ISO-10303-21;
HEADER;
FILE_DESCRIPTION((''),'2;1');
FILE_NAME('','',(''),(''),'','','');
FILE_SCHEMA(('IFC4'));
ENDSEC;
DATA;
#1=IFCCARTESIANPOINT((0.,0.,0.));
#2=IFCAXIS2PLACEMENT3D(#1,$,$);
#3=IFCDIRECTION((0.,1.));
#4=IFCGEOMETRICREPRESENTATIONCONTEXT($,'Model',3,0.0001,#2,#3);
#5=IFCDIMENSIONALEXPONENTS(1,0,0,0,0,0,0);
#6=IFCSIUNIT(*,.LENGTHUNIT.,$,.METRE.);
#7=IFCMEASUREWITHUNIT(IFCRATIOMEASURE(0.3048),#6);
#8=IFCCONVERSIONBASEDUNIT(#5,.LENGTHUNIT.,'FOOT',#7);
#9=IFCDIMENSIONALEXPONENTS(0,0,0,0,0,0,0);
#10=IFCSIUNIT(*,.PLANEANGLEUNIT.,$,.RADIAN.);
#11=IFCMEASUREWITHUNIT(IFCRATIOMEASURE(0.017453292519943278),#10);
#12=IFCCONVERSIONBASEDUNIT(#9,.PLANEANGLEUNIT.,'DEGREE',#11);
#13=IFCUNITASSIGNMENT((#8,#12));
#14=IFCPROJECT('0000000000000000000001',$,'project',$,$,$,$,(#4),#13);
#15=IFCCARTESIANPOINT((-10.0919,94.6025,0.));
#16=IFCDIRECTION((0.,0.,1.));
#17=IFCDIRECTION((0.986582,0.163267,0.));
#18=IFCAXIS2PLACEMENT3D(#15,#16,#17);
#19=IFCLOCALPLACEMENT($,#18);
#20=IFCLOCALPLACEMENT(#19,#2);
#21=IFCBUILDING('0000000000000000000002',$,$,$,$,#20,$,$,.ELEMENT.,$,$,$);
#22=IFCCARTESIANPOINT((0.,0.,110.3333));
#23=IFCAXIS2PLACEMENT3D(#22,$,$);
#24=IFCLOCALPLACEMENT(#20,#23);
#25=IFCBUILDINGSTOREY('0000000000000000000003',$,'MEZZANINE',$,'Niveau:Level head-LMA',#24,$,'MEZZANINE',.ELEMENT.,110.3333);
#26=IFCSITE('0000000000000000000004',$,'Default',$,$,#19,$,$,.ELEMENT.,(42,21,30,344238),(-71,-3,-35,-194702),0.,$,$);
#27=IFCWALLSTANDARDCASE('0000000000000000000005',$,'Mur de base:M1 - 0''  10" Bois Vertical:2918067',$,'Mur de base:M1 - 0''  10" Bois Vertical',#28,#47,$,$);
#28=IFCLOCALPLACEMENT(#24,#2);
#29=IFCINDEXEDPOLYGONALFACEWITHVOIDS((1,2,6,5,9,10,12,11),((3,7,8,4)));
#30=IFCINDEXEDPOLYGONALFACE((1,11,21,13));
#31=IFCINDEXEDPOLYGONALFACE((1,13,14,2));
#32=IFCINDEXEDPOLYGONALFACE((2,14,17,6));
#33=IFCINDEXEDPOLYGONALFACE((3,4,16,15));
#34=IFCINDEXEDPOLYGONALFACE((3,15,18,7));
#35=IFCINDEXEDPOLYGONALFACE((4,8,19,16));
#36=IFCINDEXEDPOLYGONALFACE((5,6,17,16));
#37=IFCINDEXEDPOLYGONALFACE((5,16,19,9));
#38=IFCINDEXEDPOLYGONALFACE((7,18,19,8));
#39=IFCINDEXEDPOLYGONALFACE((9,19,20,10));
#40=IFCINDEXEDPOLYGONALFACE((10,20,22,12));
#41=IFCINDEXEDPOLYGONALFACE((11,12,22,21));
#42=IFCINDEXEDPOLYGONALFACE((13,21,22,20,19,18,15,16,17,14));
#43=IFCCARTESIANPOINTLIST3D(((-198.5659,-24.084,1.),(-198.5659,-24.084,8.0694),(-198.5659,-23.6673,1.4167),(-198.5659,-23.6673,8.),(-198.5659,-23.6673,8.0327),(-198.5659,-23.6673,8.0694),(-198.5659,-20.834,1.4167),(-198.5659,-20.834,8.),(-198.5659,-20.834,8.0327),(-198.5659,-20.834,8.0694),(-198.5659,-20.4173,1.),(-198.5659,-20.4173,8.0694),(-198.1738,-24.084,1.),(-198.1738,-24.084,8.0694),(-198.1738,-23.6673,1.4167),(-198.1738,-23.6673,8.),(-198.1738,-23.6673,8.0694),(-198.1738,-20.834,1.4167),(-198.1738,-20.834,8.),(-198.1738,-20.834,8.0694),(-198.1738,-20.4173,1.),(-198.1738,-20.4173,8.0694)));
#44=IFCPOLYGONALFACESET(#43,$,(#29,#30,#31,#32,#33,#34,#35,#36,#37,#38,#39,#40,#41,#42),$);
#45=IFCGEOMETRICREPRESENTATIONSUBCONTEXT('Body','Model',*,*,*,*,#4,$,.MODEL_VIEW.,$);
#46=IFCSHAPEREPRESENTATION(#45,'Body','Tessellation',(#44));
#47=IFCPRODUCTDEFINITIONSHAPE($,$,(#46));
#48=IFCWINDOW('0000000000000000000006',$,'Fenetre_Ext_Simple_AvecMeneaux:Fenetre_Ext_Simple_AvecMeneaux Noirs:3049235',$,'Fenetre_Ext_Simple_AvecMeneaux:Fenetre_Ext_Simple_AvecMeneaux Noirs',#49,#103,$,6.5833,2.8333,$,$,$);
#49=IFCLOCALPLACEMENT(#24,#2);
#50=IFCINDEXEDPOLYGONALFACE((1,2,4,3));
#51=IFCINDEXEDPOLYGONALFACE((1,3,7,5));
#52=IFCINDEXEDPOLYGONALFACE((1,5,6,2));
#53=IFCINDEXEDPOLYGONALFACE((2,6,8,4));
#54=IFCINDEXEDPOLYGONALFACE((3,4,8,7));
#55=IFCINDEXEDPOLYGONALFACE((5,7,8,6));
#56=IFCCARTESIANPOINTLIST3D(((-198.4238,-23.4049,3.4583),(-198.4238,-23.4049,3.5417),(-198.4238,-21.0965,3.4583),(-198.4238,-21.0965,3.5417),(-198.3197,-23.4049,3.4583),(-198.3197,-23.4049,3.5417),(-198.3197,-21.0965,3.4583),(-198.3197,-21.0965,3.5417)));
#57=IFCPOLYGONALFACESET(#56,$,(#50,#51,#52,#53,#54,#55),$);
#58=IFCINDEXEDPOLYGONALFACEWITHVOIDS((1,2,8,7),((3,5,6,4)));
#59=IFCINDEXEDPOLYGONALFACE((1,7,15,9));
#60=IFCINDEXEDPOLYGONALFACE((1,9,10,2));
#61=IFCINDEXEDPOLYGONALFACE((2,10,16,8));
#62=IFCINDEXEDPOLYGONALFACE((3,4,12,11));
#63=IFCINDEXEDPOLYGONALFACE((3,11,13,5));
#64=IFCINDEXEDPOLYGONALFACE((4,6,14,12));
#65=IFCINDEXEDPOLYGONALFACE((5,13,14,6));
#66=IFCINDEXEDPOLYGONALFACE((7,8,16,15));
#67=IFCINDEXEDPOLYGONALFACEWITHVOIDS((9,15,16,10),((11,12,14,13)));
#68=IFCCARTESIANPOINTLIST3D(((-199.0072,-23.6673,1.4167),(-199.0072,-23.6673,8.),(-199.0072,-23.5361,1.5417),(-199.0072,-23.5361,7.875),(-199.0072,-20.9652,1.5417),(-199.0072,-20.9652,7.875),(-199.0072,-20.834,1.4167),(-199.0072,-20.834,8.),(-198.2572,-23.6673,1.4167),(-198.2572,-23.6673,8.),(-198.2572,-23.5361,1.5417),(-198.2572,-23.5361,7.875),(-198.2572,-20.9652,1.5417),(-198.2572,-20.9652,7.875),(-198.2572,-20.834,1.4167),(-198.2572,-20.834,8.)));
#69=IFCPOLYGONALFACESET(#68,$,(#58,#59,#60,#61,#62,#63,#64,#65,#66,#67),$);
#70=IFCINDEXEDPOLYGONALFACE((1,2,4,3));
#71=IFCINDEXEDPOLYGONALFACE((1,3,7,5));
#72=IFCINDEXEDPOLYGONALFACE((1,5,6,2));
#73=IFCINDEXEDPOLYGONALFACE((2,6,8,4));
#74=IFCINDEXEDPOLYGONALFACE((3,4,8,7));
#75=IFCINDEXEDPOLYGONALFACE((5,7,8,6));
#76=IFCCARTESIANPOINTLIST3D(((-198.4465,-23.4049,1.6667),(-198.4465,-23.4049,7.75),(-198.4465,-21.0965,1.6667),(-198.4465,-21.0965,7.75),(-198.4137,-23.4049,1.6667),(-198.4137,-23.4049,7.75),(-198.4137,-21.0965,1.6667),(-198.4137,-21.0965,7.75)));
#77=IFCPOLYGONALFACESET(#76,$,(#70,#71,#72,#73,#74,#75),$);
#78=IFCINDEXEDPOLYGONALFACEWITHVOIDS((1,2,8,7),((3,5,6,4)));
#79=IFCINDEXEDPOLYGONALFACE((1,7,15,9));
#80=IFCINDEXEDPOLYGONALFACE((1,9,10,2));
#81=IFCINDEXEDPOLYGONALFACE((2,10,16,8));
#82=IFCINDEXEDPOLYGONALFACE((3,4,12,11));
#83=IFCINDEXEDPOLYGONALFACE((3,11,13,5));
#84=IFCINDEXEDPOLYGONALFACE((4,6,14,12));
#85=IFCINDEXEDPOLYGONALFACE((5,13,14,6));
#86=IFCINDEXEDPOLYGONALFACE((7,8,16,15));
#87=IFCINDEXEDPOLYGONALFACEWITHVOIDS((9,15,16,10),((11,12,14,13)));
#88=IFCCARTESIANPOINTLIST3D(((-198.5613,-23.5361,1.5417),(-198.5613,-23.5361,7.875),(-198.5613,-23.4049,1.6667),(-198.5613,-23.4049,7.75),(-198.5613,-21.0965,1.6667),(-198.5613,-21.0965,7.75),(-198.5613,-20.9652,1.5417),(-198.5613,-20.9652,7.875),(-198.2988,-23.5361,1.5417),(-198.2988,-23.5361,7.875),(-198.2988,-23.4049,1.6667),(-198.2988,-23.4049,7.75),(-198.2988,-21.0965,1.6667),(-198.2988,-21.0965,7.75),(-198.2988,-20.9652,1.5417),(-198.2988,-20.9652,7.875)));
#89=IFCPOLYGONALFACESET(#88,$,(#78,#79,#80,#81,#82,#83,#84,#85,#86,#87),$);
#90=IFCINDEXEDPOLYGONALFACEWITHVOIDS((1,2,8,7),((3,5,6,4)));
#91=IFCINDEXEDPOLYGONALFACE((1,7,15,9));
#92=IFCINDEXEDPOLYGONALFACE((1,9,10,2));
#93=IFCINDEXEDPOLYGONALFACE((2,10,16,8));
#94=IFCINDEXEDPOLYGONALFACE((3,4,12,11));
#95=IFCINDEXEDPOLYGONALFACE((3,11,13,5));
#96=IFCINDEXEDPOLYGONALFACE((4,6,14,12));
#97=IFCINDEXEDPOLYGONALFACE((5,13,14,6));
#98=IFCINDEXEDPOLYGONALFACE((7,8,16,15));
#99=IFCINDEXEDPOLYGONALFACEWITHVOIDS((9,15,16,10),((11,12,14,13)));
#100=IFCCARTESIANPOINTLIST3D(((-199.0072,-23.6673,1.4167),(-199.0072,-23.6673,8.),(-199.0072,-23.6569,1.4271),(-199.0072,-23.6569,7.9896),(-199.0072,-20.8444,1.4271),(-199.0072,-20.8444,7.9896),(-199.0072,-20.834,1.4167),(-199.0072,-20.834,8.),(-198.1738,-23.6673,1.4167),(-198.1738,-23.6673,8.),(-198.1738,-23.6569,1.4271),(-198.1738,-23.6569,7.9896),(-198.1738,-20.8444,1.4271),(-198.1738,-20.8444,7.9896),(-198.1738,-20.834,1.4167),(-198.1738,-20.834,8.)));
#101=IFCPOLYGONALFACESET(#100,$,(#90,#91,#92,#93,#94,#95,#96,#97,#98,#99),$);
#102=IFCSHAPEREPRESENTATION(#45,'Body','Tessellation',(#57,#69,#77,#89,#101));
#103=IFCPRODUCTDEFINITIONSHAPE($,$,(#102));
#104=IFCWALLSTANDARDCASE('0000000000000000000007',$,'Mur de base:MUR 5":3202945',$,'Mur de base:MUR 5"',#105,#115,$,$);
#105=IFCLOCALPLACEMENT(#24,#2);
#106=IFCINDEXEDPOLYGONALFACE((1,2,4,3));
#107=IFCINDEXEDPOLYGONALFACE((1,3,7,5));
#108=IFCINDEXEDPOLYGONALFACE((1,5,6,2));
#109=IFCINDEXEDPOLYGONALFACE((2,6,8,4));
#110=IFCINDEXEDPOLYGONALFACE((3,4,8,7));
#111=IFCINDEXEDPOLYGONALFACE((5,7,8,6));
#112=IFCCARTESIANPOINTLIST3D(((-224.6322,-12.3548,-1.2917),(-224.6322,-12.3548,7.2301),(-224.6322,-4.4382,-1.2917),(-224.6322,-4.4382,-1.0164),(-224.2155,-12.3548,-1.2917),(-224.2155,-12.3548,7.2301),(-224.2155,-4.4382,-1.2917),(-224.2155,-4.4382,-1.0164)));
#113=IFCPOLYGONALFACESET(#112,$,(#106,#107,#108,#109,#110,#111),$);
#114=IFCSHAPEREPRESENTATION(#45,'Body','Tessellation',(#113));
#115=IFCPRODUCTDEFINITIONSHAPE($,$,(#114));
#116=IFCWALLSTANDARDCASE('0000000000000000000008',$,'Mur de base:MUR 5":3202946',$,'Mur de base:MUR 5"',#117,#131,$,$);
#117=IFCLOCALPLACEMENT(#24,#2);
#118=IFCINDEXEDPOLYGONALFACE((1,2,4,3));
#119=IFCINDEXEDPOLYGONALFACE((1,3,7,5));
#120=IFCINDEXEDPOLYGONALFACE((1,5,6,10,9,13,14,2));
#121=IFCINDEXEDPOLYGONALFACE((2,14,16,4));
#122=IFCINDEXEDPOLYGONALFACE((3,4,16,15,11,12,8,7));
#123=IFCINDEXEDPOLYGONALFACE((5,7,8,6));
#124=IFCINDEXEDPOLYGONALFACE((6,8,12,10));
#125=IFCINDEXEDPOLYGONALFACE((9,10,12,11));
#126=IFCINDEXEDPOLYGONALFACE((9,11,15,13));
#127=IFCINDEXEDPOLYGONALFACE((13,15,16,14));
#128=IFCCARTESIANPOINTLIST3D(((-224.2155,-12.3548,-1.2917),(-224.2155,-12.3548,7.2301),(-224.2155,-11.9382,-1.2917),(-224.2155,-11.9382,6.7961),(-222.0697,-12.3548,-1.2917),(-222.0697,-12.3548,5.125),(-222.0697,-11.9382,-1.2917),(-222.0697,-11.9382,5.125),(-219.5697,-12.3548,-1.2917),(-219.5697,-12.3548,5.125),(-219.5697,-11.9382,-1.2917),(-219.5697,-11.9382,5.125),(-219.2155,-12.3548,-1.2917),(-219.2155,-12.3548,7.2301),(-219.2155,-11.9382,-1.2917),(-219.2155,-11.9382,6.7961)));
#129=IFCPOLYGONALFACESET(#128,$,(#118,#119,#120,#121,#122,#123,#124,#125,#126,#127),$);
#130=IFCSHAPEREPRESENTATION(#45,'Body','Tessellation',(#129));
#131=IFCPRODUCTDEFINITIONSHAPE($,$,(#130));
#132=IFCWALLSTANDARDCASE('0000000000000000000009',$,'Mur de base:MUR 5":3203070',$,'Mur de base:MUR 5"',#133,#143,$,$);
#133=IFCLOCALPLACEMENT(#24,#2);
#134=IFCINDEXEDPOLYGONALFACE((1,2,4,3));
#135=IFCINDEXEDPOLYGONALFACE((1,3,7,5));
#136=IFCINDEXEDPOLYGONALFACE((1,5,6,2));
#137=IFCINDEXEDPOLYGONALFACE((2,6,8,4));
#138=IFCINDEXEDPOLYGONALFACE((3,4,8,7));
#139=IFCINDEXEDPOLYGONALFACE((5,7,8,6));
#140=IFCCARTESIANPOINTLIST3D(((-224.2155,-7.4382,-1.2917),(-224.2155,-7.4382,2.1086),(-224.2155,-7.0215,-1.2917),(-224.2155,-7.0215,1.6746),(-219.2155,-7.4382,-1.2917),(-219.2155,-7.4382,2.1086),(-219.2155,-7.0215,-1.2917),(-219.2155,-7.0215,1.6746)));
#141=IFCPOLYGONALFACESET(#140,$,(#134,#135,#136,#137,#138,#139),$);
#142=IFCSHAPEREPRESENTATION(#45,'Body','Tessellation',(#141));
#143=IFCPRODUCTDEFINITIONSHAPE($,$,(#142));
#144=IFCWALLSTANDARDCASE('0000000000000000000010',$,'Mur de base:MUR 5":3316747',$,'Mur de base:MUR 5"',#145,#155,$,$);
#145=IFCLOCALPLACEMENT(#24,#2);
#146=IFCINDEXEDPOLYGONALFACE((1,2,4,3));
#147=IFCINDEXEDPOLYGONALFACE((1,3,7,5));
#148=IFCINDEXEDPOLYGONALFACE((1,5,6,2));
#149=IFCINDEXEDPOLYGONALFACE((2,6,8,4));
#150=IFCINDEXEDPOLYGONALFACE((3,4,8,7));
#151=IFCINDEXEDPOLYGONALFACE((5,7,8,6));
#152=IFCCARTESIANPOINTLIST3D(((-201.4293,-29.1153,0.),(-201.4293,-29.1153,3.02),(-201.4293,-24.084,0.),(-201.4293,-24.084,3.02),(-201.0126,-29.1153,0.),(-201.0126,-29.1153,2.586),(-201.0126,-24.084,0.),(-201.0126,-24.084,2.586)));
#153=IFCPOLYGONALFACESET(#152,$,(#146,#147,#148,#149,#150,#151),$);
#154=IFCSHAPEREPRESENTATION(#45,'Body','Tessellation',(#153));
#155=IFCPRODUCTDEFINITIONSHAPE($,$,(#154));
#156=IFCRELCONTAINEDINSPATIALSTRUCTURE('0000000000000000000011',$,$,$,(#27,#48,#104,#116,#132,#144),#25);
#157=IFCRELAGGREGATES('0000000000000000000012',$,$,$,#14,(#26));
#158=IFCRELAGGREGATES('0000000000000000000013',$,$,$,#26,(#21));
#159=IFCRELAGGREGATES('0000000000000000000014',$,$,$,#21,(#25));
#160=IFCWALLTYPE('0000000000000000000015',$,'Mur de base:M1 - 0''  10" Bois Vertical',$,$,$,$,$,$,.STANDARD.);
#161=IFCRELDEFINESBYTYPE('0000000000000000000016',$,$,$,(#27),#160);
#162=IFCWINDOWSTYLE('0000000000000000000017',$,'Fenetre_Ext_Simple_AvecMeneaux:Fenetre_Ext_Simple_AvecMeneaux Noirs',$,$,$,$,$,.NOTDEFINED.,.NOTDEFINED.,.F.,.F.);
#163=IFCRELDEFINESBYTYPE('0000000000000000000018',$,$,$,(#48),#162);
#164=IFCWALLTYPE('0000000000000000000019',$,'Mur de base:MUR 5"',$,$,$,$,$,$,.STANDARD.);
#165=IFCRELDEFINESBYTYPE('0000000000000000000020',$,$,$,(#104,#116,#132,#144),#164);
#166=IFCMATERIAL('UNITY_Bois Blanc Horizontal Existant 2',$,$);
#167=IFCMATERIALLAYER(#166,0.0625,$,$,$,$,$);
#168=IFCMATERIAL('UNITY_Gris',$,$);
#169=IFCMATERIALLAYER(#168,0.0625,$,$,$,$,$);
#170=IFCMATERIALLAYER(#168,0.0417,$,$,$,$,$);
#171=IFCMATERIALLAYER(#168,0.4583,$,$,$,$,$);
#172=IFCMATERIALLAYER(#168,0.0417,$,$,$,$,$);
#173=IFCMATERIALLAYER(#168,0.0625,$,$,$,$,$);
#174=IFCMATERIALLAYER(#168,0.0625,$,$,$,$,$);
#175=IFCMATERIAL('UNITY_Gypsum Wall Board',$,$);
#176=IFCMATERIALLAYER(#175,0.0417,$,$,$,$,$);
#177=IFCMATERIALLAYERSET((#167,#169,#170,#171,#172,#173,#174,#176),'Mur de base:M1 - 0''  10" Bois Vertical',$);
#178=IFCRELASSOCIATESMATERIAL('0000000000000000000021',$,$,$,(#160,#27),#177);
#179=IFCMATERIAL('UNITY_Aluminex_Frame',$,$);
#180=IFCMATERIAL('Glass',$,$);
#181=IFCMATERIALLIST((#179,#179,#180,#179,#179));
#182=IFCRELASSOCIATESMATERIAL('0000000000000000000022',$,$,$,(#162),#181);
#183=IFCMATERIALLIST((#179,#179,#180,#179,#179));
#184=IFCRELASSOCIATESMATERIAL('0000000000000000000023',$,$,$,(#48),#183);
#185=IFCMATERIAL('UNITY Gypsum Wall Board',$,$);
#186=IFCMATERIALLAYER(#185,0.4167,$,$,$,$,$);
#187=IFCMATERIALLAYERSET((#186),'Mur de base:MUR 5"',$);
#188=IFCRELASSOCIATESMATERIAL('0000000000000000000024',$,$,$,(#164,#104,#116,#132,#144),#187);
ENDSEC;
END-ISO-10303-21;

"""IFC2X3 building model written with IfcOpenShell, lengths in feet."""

from ifc_helpers import new_model, entity, si_unit, converted_unit, direction, frame, frame_2d, origin, place, context, subcontext, project, spatial, polyline, rectangle, outline, extrude, clip, bounded_halfspace, source, transform, mapped, material, material_list, layer, layer_set, layer_usage, type_object, type_shapes, element, fill, save


model = new_model("IFC2X3")

# Units and contexts
model_context = context("Model", 3, precision=0.0001, world=origin(), true_north=direction((0.0, 1.0)))
body_context = subcontext(model_context, "Body", "Model", "MODEL_VIEW")
ifc_project = project(units=[converted_unit("LENGTHUNIT", "FOOT", entity("IfcRatioMeasure", 0.3048), si_unit("LENGTHUNIT", "METRE"), dimensions=[1, 0, 0, 0, 0, 0, 0]), converted_unit("PLANEANGLEUNIT", "DEGREE", entity("IfcRatioMeasure", 0.017453292519943278), si_unit("PLANEANGLEUNIT", "RADIAN"), dimensions=[0, 0, 0, 0, 0, 0, 0])], contexts=[model_context])

# Site, building, storey
site_placement = place(None, frame((-10.0919, 94.6025, 0.0), z_axis=(0.0, 0.0, 1.0), x_axis=(0.986582, 0.163267, 0.0)))
site = spatial("IfcSite", under=ifc_project, at=site_placement, Name="Default", CompositionType="ELEMENT", RefLatitude=(42, 21, 30, 344238), RefLongitude=(-71, -3, -35, -194702), RefElevation=0.0)
building_placement = place(site_placement, origin())
building = spatial("IfcBuilding", under=site, at=building_placement, CompositionType="ELEMENT")
storey_placement = place(building_placement, frame((0.0, 0.0, 110.3333)))
storey = spatial("IfcBuildingStorey", under=building, at=storey_placement, Name="MEZZANINE", ObjectType="Niveau:Level head-LMA", LongName="MEZZANINE", CompositionType="ELEMENT", Elevation=110.3333)

# Shared definitions
ifc_material_1 = material(Name="UNITY_Gris")

# Shared definitions
ifc_material_2 = material(Name="UNITY_Bois Blanc Horizontal Existant 2")
ifc_material_3 = material(Name="UNITY_Gypsum Wall Board")
ifc_material_4 = material(Name="UNITY_Aluminex_Frame")

# Shared definitions
ifc_layer_1 = layer(ifc_material_2, 0.0625)
ifc_layer_2 = layer(ifc_material_1, 0.0625)
ifc_layer_3 = layer(ifc_material_1, 0.0417)
ifc_layer_4 = layer(ifc_material_1, 0.4583)
ifc_layer_5 = layer(ifc_material_1, 0.0417)
ifc_layer_6 = layer(ifc_material_1, 0.0625)
ifc_layer_7 = layer(ifc_material_1, 0.0625)
ifc_layer_8 = layer(ifc_material_3, 0.0417)
ifc_layer_set_1 = layer_set([ifc_layer_1, ifc_layer_2, ifc_layer_3, ifc_layer_4, ifc_layer_5, ifc_layer_6, ifc_layer_7, ifc_layer_8], Name="Mur de base:M1 - 0'  10\" Bois Vertical")
wall_type_1 = type_object("IfcWallType", Name="Mur de base:M1 - 0'  10\" Bois Vertical", PredefinedType="STANDARD", material=ifc_layer_set_1)

# Wall, opening, window
ifc_layer_usage_1 = layer_usage(ifc_layer_set_1, "AXIS2", "NEGATIVE", 0.4167)
wall_1_placement = place(storey_placement, frame((-198.5905, -20.4173, 1.0), z_axis=(0.0, 0.0, 1.0), x_axis=(0.0, -1.0, 0.0)))
wall_1 = element("IfcWallStandardCase", 1, at=wall_1_placement, inside=storey, type_object=wall_type_1, material=ifc_layer_usage_1, Name="Mur de base:M1 - 0'  10\" Bois Vertical:2918067", ObjectType="Mur de base:M1 - 0'  10\" Bois Vertical", context=body_context, shape_type="Clipping", body=[
    clip(clip(extrude(rectangle(XDim=3.6667, YDim=0.3921, at=frame_2d((1.8333, 0.2206), x_axis=(1.0, 0.0))), origin(), (0.0, 0.0, 1.0), 7.0694), bounded_halfspace(frame((0.4167, -0.4167, 7.0694), z_axis=(0.0, 0.083045, 0.996546), x_axis=(-1.0, 0.0, 0.0)), False, frame((0.4167, -0.4167, 7.0694)), polyline([(0.0, 0.0), (2.8333, 0.0), (2.8333, 0.8333), (0.0, 0.8333), (0.0, 0.0)]))), bounded_halfspace(frame((0.0, 0.0246, 0.0), z_axis=(0.0, 0.721387, 0.692532), x_axis=(-1.0, 0.0, 0.0)), True, frame((0.0, 0.0246, 0.0), z_axis=(0.0, 0.721387, 0.692532), x_axis=(-1.0, 0.0, 0.0)), polyline([(0.0, 0.0), (0.0, 0.1011), (-0.4167, 0.1011), (-0.4167, 0.5776), (-3.25, 0.5776), (-3.25, 0.1011), (-3.6667, 0.1011), (-3.6667, 0.0), (0.0, 0.0)]))),
])
opening_1_placement = place(wall_1_placement, frame((0.4167, -0.4167, 0.4167)))
opening_1 = element("IfcOpeningElement", 2, at=opening_1_placement, cuts=wall_1, ObjectType="Opening", context=body_context, shape_type="SweptSolid", body=[
    extrude(rectangle(XDim=6.5833, YDim=2.8333, at=frame_2d((3.2917, 1.4167), x_axis=(1.0, 0.0))), frame((0.0, 0.0, 0.0), z_axis=(0.0, 1.0, 0.0), x_axis=(0.0, 0.0, 1.0)), (0.0, 0.0, 1.0), 0.8333),
])
ifc_material_5 = material(Name="Glass")
ifc_material_list_1 = material_list([ifc_material_4, ifc_material_4, ifc_material_5, ifc_material_4, ifc_material_4])
ifc_material_list_2 = material_list([ifc_material_4, ifc_material_4, ifc_material_5, ifc_material_4, ifc_material_4])
window_style_1 = type_object("IfcWindowStyle", Name="Fenetre_Ext_Simple_AvecMeneaux:Fenetre_Ext_Simple_AvecMeneaux Noirs", ConstructionType="NOTDEFINED", OperationType="NOTDEFINED", ParameterTakesPrecedence=False, Sizeable=False, material=ifc_material_list_2)
shared_shape_1 = source(origin(), body_context, "Body", "SweptSolid", [
    extrude(rectangle(XDim=0.1042, YDim=2.3084, at=frame_2d((0.0, 0.0), x_axis=(1.0, 0.0))), frame((1.4167, 0.6354, 2.0417), z_axis=(0.0, 0.0, 1.0), x_axis=(0.0, -1.0, 0.0)), (0.0, 0.0, 1.0), 0.0833),
    extrude(outline(polyline([(-3.2917, -1.4167), (3.2917, -1.4167), (3.2917, 1.4167), (-3.2917, 1.4167), (-3.2917, -1.4167)]), holes=[polyline([(-3.1667, 1.2854), (3.1667, 1.2854), (3.1667, -1.2854), (-3.1667, -1.2854), (-3.1667, 1.2854)])]), frame((1.4167, 0.0, 3.2917), z_axis=(0.0, 1.0, 0.0), x_axis=(0.0, 0.0, -1.0)), (0.0, 0.0, 1.0), 0.75),
    extrude(rectangle(XDim=0.0328, YDim=2.3084, at=frame_2d((0.0, 0.0), x_axis=(1.0, 0.0))), frame((1.4167, 0.5771, 0.25), z_axis=(0.0, 0.0, 1.0), x_axis=(0.0, 1.0, 0.0)), (0.0, 0.0, 1.0), 6.0833),
    extrude(outline(polyline([(-1.2854, -3.1667), (1.2854, -3.1667), (1.2854, 3.1667), (-1.2854, 3.1667), (-1.2854, -3.1667)]), holes=[polyline([(-1.1542, -3.0417), (-1.1542, 3.0417), (1.1542, 3.0417), (1.1542, -3.0417), (-1.1542, -3.0417)])]), frame((1.4167, 0.4459, 3.2917), z_axis=(0.0, 1.0, 0.0), x_axis=(1.0, 0.0, 0.0)), (0.0, 0.0, 1.0), 0.2625),
    extrude(outline(polyline([(-1.4167, -3.2917), (1.4167, -3.2917), (1.4167, 3.2917), (-1.4167, 3.2917), (-1.4167, -3.2917)]), holes=[polyline([(1.4062, -3.2812), (-1.4062, -3.2812), (-1.4062, 3.2812), (1.4062, 3.2812), (1.4062, -3.2812)])]), frame((1.4167, 0.0, 3.2917), z_axis=(0.0, 1.0, 0.0), x_axis=(1.0, 0.0, 0.0)), (0.0, 0.0, 1.0), 0.8333),
])
type_shapes(window_style_1, [shared_shape_1])
window_1_placement = place(opening_1_placement, origin())
window_1 = element("IfcWindow", 3, at=window_1_placement, inside=storey, type_object=window_style_1, material=ifc_material_list_1, Name="Fenetre_Ext_Simple_AvecMeneaux:Fenetre_Ext_Simple_AvecMeneaux Noirs:3049235", ObjectType="Fenetre_Ext_Simple_AvecMeneaux:Fenetre_Ext_Simple_AvecMeneaux Noirs", OverallHeight=6.5833, OverallWidth=2.8333, context=body_context, shape_type="MappedRepresentation", body=[
    mapped(shared_shape_1, transform((0.0, 0.0, 0.0), scale=1.0)),
])
fill(opening_1, window_1)

# Wall
ifc_material_6 = material(Name="UNITY Gypsum Wall Board")
ifc_layer_9 = layer(ifc_material_6, 0.4167)
ifc_layer_set_2 = layer_set([ifc_layer_9], Name="Mur de base:MUR 5\"")
ifc_layer_usage_2 = layer_usage(ifc_layer_set_2, "AXIS2", "NEGATIVE", 0.2083)
wall_type_2 = type_object("IfcWallType", Name="Mur de base:MUR 5\"", PredefinedType="STANDARD", material=ifc_layer_set_2)
wall_2_placement = place(storey_placement, frame((-224.4238, -12.3548, -1.2917), z_axis=(0.0, 0.0, 1.0), x_axis=(0.0, 1.0, 0.0)))
element("IfcWallStandardCase", 4, at=wall_2_placement, inside=storey, type_object=wall_type_2, material=ifc_layer_usage_2, Name="Mur de base:MUR 5\":3202945", ObjectType="Mur de base:MUR 5\"", context=body_context, shape_type="Clipping", body=[
    clip(extrude(rectangle(XDim=7.9167, YDim=0.4167, at=frame_2d((3.9583, 0.0), x_axis=(-1.0, 0.0))), origin(), (0.0, 0.0, 1.0), 8.5218), bounded_halfspace(frame((0.0, -0.2083, 8.5218), z_axis=(0.721387, 0.0, 0.692532), x_axis=(0.0, 1.0, 0.0)), False, frame((0.0, -0.2083, 8.5218)), polyline([(0.0, 0.0), (0.4167, 0.0), (4.9167, 0.0), (5.3333, 0.0), (7.9167, 0.0), (7.9167, 0.4167), (0.0, 0.4167), (0.0, 0.0)]))),
])

# Wall, opening
ifc_layer_usage_3 = layer_usage(ifc_layer_set_2, "AXIS2", "POSITIVE", -0.2083)
wall_3_placement = place(storey_placement, frame((-224.2155, -12.1465, -1.2917)))
wall_3 = element("IfcWallStandardCase", 5, at=wall_3_placement, inside=storey, type_object=wall_type_2, material=ifc_layer_usage_3, Name="Mur de base:MUR 5\":3202946", ObjectType="Mur de base:MUR 5\"", context=body_context, shape_type="Clipping", body=[
    clip(extrude(rectangle(XDim=5.0, YDim=0.4167, at=frame_2d((2.5, 0.0), x_axis=(-1.0, 0.0))), origin(), (0.0, 0.0, 1.0), 8.5218), bounded_halfspace(frame((0.0, -0.2083, 8.5218), z_axis=(0.0, 0.721387, 0.692532), x_axis=(-1.0, 0.0, 0.0)), False, frame((0.0, -0.2083, 8.5218)), polyline([(0.0, 0.0), (5.0, 0.0), (5.0, 0.4167), (0.0, 0.4167), (0.0, 0.0)]))),
])
opening_2_placement = place(wall_3_placement, frame((224.2155, 12.1465, 1.2917)))
element("IfcOpeningElement", 6, at=opening_2_placement, cuts=wall_3, ObjectType="Opening", context=body_context, shape_type="SweptSolid", body=[
    extrude(rectangle(XDim=6.4167, YDim=2.5, at=frame_2d((0.0, 0.0), x_axis=(0.0, 1.0))), frame((-220.8197, -17.3548, 1.9167), z_axis=(0.0, 1.0, 0.0), x_axis=(-1.0, 0.0, 0.0)), (0.0, 0.0, 1.0), 10.0),
])

# Walls
ifc_layer_usage_4 = layer_usage(ifc_layer_set_2, "AXIS2", "POSITIVE", -0.2083)
wall_4_placement = place(storey_placement, frame((-224.2155, -7.2298, -1.2917)))
element("IfcWallStandardCase", 7, at=wall_4_placement, inside=storey, type_object=wall_type_2, material=ifc_layer_usage_4, Name="Mur de base:MUR 5\":3203070", ObjectType="Mur de base:MUR 5\"", context=body_context, shape_type="Clipping", body=[
    clip(extrude(rectangle(XDim=5.0, YDim=0.4167, at=frame_2d((2.5, 0.0), x_axis=(-1.0, 0.0))), origin(), (0.0, 0.0, 1.0), 3.4003), bounded_halfspace(frame((0.0, -0.2083, 3.4003), z_axis=(0.0, 0.721387, 0.692532), x_axis=(-1.0, 0.0, 0.0)), False, frame((0.0, -0.2083, 3.4003)), polyline([(0.0, 0.0), (5.0, 0.0), (5.0, 0.4167), (0.0, 0.4167), (0.0, 0.0)]))),
])
ifc_layer_usage_5 = layer_usage(ifc_layer_set_2, "AXIS2", "NEGATIVE", 0.2083)
wall_5_placement = place(storey_placement, frame((-201.2209, -29.1153, 0.0), z_axis=(0.0, 0.0, 1.0), x_axis=(0.0, 1.0, 0.0)))
element("IfcWallStandardCase", 8, at=wall_5_placement, inside=storey, type_object=wall_type_2, material=ifc_layer_usage_5, Name="Mur de base:MUR 5\":3316747", ObjectType="Mur de base:MUR 5\"", context=body_context, shape_type="Clipping", body=[
    clip(extrude(rectangle(XDim=5.0312, YDim=0.4167, at=frame_2d((2.5156, 0.0), x_axis=(-1.0, 0.0))), origin(), (0.0, 0.0, 1.0), 3.02), bounded_halfspace(frame((0.0, -0.2083, 2.586), z_axis=(0.0, -0.721387, 0.692532), x_axis=(1.0, 0.0, 0.0)), False, frame((0.0, -0.2083, 2.586)), polyline([(0.0, 0.0), (0.4167, 0.0), (5.0312, 0.0), (5.0312, 0.4167), (0.0, 0.4167), (0.0, 0.0)]))),
])

save(model, "model.ifc")
